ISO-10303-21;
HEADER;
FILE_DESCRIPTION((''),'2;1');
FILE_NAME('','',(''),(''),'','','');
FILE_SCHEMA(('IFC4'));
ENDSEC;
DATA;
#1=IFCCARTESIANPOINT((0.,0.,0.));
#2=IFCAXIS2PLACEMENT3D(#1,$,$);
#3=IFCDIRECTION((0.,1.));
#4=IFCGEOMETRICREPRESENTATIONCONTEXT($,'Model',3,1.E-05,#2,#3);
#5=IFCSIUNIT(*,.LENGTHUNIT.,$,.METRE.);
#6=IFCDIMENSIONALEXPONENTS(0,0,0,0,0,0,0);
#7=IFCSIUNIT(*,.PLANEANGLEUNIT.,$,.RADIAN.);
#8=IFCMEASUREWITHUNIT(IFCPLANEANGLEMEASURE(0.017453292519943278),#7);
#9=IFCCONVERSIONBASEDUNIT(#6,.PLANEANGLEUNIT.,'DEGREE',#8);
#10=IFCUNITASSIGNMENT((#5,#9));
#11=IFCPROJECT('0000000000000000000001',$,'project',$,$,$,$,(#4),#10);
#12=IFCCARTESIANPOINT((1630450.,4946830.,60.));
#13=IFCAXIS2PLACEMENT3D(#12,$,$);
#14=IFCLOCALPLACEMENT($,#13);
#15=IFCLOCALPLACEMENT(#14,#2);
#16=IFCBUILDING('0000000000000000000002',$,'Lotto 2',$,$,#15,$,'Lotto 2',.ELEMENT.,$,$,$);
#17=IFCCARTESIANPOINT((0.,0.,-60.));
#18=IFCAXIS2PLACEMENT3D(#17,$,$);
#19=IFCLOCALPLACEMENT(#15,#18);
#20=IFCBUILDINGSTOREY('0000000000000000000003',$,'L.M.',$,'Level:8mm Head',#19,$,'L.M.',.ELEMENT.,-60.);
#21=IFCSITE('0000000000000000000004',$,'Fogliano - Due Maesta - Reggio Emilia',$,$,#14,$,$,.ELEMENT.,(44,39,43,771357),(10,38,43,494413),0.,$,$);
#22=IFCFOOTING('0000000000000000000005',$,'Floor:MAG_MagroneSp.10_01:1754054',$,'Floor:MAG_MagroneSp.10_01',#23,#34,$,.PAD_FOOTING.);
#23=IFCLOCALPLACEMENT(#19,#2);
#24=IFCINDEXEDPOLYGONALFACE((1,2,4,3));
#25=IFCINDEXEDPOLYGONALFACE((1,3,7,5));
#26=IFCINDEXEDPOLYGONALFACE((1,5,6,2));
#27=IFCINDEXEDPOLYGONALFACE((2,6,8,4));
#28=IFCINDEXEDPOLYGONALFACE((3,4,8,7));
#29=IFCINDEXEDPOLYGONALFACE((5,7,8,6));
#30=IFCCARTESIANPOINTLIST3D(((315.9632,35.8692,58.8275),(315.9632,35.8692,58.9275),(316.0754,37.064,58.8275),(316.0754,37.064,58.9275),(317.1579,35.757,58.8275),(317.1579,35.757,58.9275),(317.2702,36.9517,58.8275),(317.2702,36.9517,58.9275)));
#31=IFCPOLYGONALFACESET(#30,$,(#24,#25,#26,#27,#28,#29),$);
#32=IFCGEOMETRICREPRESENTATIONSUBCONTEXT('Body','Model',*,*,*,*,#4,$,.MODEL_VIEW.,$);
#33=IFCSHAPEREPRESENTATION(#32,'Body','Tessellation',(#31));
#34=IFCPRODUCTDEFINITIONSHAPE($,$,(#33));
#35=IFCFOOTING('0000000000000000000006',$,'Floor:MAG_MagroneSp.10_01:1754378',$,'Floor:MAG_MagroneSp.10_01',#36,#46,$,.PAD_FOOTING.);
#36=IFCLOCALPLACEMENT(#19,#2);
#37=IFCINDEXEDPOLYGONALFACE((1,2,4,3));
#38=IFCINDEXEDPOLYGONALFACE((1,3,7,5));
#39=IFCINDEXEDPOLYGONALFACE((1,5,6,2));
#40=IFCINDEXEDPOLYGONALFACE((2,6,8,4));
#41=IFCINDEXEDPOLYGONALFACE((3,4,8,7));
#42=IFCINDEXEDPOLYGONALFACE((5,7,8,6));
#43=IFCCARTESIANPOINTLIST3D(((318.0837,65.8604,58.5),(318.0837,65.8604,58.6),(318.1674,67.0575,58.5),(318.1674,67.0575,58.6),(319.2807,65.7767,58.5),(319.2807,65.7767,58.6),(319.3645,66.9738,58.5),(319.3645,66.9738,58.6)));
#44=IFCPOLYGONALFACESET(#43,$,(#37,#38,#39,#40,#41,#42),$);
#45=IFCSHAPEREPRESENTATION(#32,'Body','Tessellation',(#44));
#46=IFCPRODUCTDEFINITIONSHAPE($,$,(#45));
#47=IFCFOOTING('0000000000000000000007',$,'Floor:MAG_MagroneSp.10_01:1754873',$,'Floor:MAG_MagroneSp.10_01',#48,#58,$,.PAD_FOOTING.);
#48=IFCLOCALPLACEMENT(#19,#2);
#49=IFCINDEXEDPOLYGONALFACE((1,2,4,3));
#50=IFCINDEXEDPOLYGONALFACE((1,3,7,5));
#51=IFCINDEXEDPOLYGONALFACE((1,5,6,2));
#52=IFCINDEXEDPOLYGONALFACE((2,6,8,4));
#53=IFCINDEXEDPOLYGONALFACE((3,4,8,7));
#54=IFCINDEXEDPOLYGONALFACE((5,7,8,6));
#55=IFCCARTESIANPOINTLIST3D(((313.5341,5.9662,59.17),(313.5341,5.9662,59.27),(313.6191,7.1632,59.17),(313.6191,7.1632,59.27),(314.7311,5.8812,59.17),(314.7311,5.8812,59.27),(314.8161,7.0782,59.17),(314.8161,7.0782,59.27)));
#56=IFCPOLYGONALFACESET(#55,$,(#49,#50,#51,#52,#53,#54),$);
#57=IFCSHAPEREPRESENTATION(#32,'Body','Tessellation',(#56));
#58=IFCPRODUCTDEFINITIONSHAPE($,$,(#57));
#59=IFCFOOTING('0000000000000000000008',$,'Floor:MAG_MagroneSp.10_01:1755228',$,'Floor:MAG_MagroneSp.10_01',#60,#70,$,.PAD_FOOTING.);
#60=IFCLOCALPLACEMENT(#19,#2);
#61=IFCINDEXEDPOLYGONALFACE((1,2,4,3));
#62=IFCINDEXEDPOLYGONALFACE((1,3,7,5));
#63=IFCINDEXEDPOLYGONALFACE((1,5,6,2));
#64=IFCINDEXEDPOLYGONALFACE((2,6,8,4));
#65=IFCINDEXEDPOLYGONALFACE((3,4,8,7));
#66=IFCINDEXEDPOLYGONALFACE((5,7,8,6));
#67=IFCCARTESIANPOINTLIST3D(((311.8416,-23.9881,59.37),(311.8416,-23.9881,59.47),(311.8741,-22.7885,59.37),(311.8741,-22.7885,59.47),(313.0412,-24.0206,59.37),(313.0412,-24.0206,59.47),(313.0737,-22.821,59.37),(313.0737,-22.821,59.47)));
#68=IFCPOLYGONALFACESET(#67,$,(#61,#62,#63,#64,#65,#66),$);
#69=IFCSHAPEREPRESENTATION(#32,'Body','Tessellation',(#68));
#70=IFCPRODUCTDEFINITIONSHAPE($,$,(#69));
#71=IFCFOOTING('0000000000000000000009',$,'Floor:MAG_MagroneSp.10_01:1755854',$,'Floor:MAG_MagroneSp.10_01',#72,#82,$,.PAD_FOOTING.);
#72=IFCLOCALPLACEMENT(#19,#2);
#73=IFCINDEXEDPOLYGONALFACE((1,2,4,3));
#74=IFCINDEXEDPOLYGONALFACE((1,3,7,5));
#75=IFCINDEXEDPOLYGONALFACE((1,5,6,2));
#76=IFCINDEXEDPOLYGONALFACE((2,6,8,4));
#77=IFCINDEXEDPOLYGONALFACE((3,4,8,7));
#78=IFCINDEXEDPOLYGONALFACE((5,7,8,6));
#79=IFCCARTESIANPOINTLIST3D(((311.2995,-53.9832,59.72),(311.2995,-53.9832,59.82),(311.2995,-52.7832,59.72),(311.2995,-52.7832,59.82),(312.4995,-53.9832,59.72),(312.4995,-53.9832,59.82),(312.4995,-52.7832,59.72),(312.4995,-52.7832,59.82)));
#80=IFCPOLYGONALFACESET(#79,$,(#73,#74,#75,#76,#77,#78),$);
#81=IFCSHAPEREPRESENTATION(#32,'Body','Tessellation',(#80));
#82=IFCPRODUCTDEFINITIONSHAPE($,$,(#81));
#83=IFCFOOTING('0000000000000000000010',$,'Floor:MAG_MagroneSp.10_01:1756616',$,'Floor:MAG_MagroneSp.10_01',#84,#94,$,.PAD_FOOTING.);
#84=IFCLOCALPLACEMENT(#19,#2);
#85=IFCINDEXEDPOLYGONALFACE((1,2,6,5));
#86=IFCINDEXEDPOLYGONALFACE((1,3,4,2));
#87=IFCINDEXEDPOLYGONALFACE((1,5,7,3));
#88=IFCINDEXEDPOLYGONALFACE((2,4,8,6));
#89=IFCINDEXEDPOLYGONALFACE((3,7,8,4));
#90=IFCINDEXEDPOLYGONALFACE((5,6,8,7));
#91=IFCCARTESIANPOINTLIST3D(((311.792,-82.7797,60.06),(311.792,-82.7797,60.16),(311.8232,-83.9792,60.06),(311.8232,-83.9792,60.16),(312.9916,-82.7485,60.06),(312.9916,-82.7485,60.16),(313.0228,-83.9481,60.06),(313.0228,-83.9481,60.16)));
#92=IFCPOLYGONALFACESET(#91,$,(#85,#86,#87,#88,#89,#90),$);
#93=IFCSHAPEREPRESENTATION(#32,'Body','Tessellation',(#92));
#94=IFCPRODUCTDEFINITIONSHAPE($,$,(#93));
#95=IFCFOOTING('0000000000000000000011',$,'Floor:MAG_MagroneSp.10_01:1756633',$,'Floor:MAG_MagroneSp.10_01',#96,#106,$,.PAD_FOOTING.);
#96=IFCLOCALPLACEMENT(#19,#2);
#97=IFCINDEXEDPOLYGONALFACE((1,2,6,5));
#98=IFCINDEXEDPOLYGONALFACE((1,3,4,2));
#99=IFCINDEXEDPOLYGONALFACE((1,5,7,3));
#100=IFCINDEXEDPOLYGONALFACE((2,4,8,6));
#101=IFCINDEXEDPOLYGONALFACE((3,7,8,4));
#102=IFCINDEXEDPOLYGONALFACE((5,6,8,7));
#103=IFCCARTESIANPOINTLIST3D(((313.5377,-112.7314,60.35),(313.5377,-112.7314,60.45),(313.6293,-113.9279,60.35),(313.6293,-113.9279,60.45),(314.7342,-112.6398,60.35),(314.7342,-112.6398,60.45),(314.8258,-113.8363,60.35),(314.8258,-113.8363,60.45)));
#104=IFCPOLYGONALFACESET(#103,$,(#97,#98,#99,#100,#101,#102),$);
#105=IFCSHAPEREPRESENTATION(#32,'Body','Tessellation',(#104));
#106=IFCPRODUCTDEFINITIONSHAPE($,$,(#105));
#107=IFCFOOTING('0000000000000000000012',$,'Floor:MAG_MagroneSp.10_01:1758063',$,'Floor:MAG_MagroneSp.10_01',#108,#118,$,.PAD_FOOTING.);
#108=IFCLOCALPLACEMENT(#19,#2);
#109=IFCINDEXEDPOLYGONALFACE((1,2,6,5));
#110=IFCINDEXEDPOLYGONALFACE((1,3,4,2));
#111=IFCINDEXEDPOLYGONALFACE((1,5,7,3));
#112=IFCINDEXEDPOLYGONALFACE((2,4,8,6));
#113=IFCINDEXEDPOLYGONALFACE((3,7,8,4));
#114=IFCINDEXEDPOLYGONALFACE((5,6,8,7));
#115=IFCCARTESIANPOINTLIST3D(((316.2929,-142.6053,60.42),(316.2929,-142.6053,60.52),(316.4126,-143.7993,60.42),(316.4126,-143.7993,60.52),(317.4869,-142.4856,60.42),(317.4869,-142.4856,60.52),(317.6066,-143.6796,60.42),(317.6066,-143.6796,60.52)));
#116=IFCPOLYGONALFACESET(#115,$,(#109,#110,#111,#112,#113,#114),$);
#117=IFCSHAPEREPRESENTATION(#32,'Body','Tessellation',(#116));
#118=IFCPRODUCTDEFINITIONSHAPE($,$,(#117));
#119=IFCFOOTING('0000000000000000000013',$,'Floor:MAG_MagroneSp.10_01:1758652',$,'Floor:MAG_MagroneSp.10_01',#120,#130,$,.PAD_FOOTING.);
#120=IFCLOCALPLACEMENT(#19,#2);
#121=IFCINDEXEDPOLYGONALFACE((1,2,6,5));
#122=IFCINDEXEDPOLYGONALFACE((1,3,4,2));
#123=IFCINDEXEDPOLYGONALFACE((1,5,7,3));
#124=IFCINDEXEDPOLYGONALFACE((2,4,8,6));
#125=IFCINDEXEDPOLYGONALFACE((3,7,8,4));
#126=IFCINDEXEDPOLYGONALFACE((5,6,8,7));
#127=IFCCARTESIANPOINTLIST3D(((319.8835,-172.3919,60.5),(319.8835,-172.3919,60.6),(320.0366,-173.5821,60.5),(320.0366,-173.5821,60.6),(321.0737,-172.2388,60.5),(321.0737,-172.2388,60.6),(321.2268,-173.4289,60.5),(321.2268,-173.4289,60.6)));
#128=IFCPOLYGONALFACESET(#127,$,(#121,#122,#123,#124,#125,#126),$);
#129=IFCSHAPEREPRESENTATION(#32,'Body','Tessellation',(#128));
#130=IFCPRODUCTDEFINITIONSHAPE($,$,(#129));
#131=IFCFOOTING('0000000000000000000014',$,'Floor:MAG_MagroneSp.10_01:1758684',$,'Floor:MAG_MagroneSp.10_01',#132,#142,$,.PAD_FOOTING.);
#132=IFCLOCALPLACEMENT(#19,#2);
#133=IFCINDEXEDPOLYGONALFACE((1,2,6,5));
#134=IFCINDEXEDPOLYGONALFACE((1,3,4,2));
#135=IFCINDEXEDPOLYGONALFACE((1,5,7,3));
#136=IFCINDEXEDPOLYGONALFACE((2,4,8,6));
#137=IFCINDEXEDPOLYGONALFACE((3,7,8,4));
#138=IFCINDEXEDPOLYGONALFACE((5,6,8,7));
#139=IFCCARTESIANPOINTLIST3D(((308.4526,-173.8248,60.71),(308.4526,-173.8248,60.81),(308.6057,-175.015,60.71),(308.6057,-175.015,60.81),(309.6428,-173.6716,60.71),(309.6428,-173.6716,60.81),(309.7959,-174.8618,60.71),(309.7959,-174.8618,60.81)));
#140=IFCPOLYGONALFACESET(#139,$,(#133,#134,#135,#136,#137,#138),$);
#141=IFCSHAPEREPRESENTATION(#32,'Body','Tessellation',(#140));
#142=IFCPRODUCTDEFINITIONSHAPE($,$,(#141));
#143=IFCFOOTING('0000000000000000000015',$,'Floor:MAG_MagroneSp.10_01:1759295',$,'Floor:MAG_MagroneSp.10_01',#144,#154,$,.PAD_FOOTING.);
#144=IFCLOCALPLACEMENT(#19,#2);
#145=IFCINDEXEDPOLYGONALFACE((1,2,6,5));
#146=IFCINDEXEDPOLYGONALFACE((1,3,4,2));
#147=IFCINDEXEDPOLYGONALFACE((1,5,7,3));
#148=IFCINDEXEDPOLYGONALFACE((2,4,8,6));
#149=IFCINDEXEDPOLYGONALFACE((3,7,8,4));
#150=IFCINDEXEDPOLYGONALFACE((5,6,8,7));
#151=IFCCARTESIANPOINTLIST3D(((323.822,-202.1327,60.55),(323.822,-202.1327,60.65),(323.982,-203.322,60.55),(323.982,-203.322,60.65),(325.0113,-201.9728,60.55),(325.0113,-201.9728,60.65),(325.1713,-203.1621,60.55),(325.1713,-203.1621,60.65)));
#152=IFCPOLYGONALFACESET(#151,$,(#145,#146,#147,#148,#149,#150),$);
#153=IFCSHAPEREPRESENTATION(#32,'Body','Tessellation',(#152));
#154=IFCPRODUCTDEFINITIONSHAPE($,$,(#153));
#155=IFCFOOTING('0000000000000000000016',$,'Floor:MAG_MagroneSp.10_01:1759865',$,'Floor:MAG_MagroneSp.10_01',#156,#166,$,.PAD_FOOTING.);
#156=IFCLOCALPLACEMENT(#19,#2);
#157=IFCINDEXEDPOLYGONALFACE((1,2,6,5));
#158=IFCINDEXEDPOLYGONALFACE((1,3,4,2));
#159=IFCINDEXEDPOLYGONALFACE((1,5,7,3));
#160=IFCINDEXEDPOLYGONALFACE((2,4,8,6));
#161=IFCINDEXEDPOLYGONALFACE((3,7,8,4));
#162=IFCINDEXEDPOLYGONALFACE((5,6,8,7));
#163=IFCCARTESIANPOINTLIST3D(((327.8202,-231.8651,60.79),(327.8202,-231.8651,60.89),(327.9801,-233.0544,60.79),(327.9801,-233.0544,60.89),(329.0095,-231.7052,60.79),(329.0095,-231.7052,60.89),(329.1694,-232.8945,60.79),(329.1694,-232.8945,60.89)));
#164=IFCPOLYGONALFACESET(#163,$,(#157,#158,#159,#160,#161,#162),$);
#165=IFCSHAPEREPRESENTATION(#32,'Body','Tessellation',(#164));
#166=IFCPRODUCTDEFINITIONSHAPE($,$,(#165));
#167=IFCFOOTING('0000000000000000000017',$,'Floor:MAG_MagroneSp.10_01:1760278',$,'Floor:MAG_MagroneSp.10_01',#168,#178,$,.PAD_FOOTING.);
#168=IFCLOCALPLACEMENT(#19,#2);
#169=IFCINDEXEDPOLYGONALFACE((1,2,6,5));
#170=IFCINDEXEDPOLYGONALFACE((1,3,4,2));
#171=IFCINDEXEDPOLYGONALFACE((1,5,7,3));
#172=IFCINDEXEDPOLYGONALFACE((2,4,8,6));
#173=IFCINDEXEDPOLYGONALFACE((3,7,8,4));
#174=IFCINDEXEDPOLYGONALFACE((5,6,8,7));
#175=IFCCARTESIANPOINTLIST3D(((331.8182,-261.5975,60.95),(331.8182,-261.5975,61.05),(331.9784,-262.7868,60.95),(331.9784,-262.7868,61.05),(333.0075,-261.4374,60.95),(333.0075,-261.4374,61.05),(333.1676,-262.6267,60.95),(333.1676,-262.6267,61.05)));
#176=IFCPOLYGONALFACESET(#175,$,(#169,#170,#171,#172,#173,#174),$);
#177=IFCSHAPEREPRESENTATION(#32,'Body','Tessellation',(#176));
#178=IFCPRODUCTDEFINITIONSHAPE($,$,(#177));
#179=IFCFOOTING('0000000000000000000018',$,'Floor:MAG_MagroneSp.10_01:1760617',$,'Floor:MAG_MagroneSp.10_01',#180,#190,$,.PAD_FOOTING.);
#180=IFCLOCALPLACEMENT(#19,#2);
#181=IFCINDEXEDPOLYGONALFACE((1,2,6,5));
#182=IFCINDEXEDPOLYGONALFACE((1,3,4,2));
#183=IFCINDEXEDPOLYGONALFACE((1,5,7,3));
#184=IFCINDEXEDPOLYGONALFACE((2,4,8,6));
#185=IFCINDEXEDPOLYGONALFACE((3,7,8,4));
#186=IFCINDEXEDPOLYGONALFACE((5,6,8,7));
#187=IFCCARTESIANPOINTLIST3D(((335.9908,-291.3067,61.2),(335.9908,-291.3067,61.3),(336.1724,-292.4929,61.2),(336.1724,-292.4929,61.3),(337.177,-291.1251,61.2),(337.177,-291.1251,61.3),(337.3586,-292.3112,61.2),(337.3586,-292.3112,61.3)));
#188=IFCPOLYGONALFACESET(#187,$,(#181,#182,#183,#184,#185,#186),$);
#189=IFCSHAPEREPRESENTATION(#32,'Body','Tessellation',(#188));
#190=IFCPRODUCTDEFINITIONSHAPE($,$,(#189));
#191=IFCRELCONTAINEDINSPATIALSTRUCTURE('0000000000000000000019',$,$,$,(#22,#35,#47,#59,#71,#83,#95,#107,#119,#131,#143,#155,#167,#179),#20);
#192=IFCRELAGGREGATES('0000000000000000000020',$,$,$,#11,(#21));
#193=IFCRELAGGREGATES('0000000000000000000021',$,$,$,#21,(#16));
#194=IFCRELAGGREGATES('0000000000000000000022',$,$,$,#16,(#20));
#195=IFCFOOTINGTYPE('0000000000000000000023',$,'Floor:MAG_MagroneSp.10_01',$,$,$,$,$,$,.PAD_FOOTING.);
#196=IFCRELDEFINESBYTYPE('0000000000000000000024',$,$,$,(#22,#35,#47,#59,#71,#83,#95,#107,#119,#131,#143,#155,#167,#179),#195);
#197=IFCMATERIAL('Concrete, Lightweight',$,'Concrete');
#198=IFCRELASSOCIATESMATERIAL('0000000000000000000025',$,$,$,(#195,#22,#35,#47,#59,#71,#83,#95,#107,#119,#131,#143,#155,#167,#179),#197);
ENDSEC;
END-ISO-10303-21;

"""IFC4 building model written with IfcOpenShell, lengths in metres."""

from ifc_helpers import new_model, entity, si_unit, converted_unit, direction, frame, origin, place, context, subcontext, project, spatial, indexed_curve, outline, extrude, material, type_object, element, save


model = new_model("IFC4")

# Units and contexts
model_context = context("Model", 3, precision=1e-05, world=origin(), true_north=direction((0.0, 1.0)))
body_context = subcontext(model_context, "Body", "Model", "MODEL_VIEW")
ifc_project = project(units=[si_unit("LENGTHUNIT", "METRE"), converted_unit("PLANEANGLEUNIT", "DEGREE", entity("IfcPlaneAngleMeasure", 0.017453292519943278), si_unit("PLANEANGLEUNIT", "RADIAN"), dimensions=[0, 0, 0, 0, 0, 0, 0])], contexts=[model_context])

# Site, building, storey
site_placement = place(None, frame((1630450.0, 4946830.0, 60.0)))
site = spatial("IfcSite", under=ifc_project, at=site_placement, Name="Fogliano - Due Maesta - Reggio Emilia", CompositionType="ELEMENT", RefLatitude=(44, 39, 43, 771357), RefLongitude=(10, 38, 43, 494413), RefElevation=0.0)
building_placement = place(site_placement, origin())
building = spatial("IfcBuilding", under=site, at=building_placement, Name="Lotto 2", LongName="Lotto 2", CompositionType="ELEMENT")
storey_placement = place(building_placement, frame((0.0, 0.0, -60.0)))
storey = spatial("IfcBuildingStorey", under=building, at=storey_placement, Name="L.M.", ObjectType="Level:8mm Head", LongName="L.M.", CompositionType="ELEMENT", Elevation=-60.0)

# Footings
ifc_material = material(Name="Concrete, Lightweight", Category="Concrete")
footing_type = type_object("IfcFootingType", Name="Floor:MAG_MagroneSp.10_01", PredefinedType="PAD_FOOTING", material=ifc_material)
footing_1_placement = place(storey_placement, origin())
element("IfcFooting", 1, at=footing_1_placement, inside=storey, type_object=footing_type, material=ifc_material, Name="Floor:MAG_MagroneSp.10_01:1754054", ObjectType="Floor:MAG_MagroneSp.10_01", PredefinedType="PAD_FOOTING", context=body_context, shape_type="SweptSolid", body=[
    extrude(outline(indexed_curve([(-0.6, -0.6), (0.6, -0.6), (0.6, 0.6), (-0.6, 0.6), (-0.6, -0.6)], self_intersect=False)), frame((316.6167, 36.4105, 58.9275), z_axis=(0.0, 0.0, -1.0), x_axis=(-0.093547, -0.995615, 0.0)), (0.0, 0.0, 1.0), 0.1),
])
footing_2_placement = place(storey_placement, origin())
element("IfcFooting", 2, at=footing_2_placement, inside=storey, type_object=footing_type, material=ifc_material, Name="Floor:MAG_MagroneSp.10_01:1754378", ObjectType="Floor:MAG_MagroneSp.10_01", PredefinedType="PAD_FOOTING", context=body_context, shape_type="SweptSolid", body=[
    extrude(outline(indexed_curve([(-0.6, -0.6), (0.6, -0.6), (0.6, 0.6), (-0.6, 0.6), (-0.6, -0.6)], self_intersect=False)), frame((318.7241, 66.4171, 58.6), z_axis=(0.0, 0.0, -1.0), x_axis=(-0.069761, -0.997564, 0.0)), (0.0, 0.0, 1.0), 0.1),
])
footing_3_placement = place(storey_placement, origin())
element("IfcFooting", 3, at=footing_3_placement, inside=storey, type_object=footing_type, material=ifc_material, Name="Floor:MAG_MagroneSp.10_01:1754873", ObjectType="Floor:MAG_MagroneSp.10_01", PredefinedType="PAD_FOOTING", context=body_context, shape_type="SweptSolid", body=[
    extrude(outline(indexed_curve([(-0.6, -0.6), (0.6, -0.6), (0.6, 0.6), (-0.6, 0.6), (-0.6, -0.6)], self_intersect=False)), frame((314.1751, 6.5222, 59.27), z_axis=(0.0, 0.0, -1.0), x_axis=(-0.070823, -0.997489, 0.0)), (0.0, 0.0, 1.0), 0.1),
])
footing_4_placement = place(storey_placement, origin())
element("IfcFooting", 4, at=footing_4_placement, inside=storey, type_object=footing_type, material=ifc_material, Name="Floor:MAG_MagroneSp.10_01:1755228", ObjectType="Floor:MAG_MagroneSp.10_01", PredefinedType="PAD_FOOTING", context=body_context, shape_type="SweptSolid", body=[
    extrude(outline(indexed_curve([(-0.6, -0.6), (0.6, -0.6), (0.6, 0.6), (-0.6, 0.6), (-0.6, -0.6)], self_intersect=False)), frame((312.4576, -23.4046, 59.47), z_axis=(0.0, 0.0, -1.0), x_axis=(-0.027091, -0.999633, 0.0)), (0.0, 0.0, 1.0), 0.1),
])
footing_5_placement = place(storey_placement, origin())
element("IfcFooting", 5, at=footing_5_placement, inside=storey, type_object=footing_type, material=ifc_material, Name="Floor:MAG_MagroneSp.10_01:1755854", ObjectType="Floor:MAG_MagroneSp.10_01", PredefinedType="PAD_FOOTING", context=body_context, shape_type="SweptSolid", body=[
    extrude(outline(indexed_curve([(-0.6, -0.6), (0.6, -0.6), (0.6, 0.6), (-0.6, 0.6), (-0.6, -0.6)], self_intersect=False)), frame((311.8995, -53.3832, 59.82), z_axis=(0.0, 0.0, -1.0), x_axis=(0.0, 1.0, 0.0)), (0.0, 0.0, 1.0), 0.1),
])
footing_6_placement = place(storey_placement, origin())
element("IfcFooting", 6, at=footing_6_placement, inside=storey, type_object=footing_type, material=ifc_material, Name="Floor:MAG_MagroneSp.10_01:1756616", ObjectType="Floor:MAG_MagroneSp.10_01", PredefinedType="PAD_FOOTING", context=body_context, shape_type="SweptSolid", body=[
    extrude(outline(indexed_curve([(-0.6, -0.6), (0.6, -0.6), (0.6, 0.6), (-0.6, 0.6), (-0.6, -0.6)], self_intersect=False)), frame((312.4074, -83.3639, 60.16), z_axis=(0.0, 0.0, -1.0), x_axis=(0.025993, -0.999662, 0.0)), (0.0, 0.0, 1.0), 0.1),
])
footing_7_placement = place(storey_placement, origin())
element("IfcFooting", 7, at=footing_7_placement, inside=storey, type_object=footing_type, material=ifc_material, Name="Floor:MAG_MagroneSp.10_01:1756633", ObjectType="Floor:MAG_MagroneSp.10_01", PredefinedType="PAD_FOOTING", context=body_context, shape_type="SweptSolid", body=[
    extrude(outline(indexed_curve([(-0.6, -0.6), (0.6, -0.6), (0.6, 0.6), (-0.6, 0.6), (-0.6, -0.6)], self_intersect=False)), frame((314.1817, -113.2838, 60.45), z_axis=(0.0, 0.0, -1.0), x_axis=(0.076316, -0.997084, 0.0)), (0.0, 0.0, 1.0), 0.1),
])
footing_8_placement = place(storey_placement, origin())
element("IfcFooting", 8, at=footing_8_placement, inside=storey, type_object=footing_type, material=ifc_material, Name="Floor:MAG_MagroneSp.10_01:1758063", ObjectType="Floor:MAG_MagroneSp.10_01", PredefinedType="PAD_FOOTING", context=body_context, shape_type="SweptSolid", body=[
    extrude(outline(indexed_curve([(-0.6, -0.6), (0.6, -0.6), (0.6, 0.6), (-0.6, 0.6), (-0.6, -0.6)], self_intersect=False)), frame((316.9497, -143.1424, 60.52), z_axis=(0.0, 0.0, -1.0), x_axis=(0.099742, -0.995013, 0.0)), (0.0, 0.0, 1.0), 0.1),
])
footing_9_placement = place(storey_placement, origin())
element("IfcFooting", 9, at=footing_9_placement, inside=storey, type_object=footing_type, material=ifc_material, Name="Floor:MAG_MagroneSp.10_01:1758652", ObjectType="Floor:MAG_MagroneSp.10_01", PredefinedType="PAD_FOOTING", context=body_context, shape_type="SweptSolid", body=[
    extrude(outline(indexed_curve([(-0.6, -0.6), (0.6, -0.6), (0.6, 0.6), (-0.6, 0.6), (-0.6, -0.6)], self_intersect=False)), frame((320.5552, -172.9104, 60.6), z_axis=(0.0, 0.0, -1.0), x_axis=(0.127625, -0.991822, 0.0)), (0.0, 0.0, 1.0), 0.1),
])
footing_10_placement = place(storey_placement, origin())
element("IfcFooting", 10, at=footing_10_placement, inside=storey, type_object=footing_type, material=ifc_material, Name="Floor:MAG_MagroneSp.10_01:1758684", ObjectType="Floor:MAG_MagroneSp.10_01", PredefinedType="PAD_FOOTING", context=body_context, shape_type="SweptSolid", body=[
    extrude(outline(indexed_curve([(-0.6, -0.6), (0.6, -0.6), (0.6, 0.6), (-0.6, 0.6), (-0.6, -0.6)], self_intersect=False)), frame((309.1243, -174.3433, 60.81), z_axis=(0.0, 0.0, -1.0), x_axis=(0.127625, -0.991822, 0.0)), (0.0, 0.0, 1.0), 0.1),
])
footing_11_placement = place(storey_placement, origin())
element("IfcFooting", 11, at=footing_11_placement, inside=storey, type_object=footing_type, material=ifc_material, Name="Floor:MAG_MagroneSp.10_01:1759295", ObjectType="Floor:MAG_MagroneSp.10_01", PredefinedType="PAD_FOOTING", context=body_context, shape_type="SweptSolid", body=[
    extrude(outline(indexed_curve([(-0.6, -0.6), (0.6, -0.6), (0.6, 0.6), (-0.6, 0.6), (-0.6, -0.6)], self_intersect=False)), frame((324.4966, -202.6474, 60.65), z_axis=(0.0, 0.0, -1.0), x_axis=(0.133272, -0.991079, 0.0)), (0.0, 0.0, 1.0), 0.1),
])
footing_12_placement = place(storey_placement, origin())
element("IfcFooting", 12, at=footing_12_placement, inside=storey, type_object=footing_type, material=ifc_material, Name="Floor:MAG_MagroneSp.10_01:1759865", ObjectType="Floor:MAG_MagroneSp.10_01", PredefinedType="PAD_FOOTING", context=body_context, shape_type="SweptSolid", body=[
    extrude(outline(indexed_curve([(-0.6, -0.6), (0.6, -0.6), (0.6, 0.6), (-0.6, 0.6), (-0.6, -0.6)], self_intersect=False)), frame((328.4948, -232.3798, 60.89), z_axis=(0.0, 0.0, -1.0), x_axis=(0.133272, -0.991079, 0.0)), (0.0, 0.0, 1.0), 0.1),
])
footing_13_placement = place(storey_placement, origin())
element("IfcFooting", 13, at=footing_13_placement, inside=storey, type_object=footing_type, material=ifc_material, Name="Floor:MAG_MagroneSp.10_01:1760278", ObjectType="Floor:MAG_MagroneSp.10_01", PredefinedType="PAD_FOOTING", context=body_context, shape_type="SweptSolid", body=[
    extrude(outline(indexed_curve([(-0.6, -0.6), (0.6, -0.6), (0.6, 0.6), (-0.6, 0.6), (-0.6, -0.6)], self_intersect=False)), frame((332.4929, -262.1121, 61.05), z_axis=(0.0, 0.0, -1.0), x_axis=(0.133439, -0.991057, 0.0)), (0.0, 0.0, 1.0), 0.1),
])
footing_14_placement = place(storey_placement, origin())
element("IfcFooting", 14, at=footing_14_placement, inside=storey, type_object=footing_type, material=ifc_material, Name="Floor:MAG_MagroneSp.10_01:1760617", ObjectType="Floor:MAG_MagroneSp.10_01", PredefinedType="PAD_FOOTING", context=body_context, shape_type="SweptSolid", body=[
    extrude(outline(indexed_curve([(-0.6, -0.6), (0.6, -0.6), (0.6, 0.6), (-0.6, 0.6), (-0.6, -0.6)], self_intersect=False)), frame((336.6747, -291.809, 61.3), z_axis=(0.0, 0.0, -1.0), x_axis=(0.151347, -0.988481, 0.0)), (0.0, 0.0, 1.0), 0.1),
])

save(model, "model.ifc")
